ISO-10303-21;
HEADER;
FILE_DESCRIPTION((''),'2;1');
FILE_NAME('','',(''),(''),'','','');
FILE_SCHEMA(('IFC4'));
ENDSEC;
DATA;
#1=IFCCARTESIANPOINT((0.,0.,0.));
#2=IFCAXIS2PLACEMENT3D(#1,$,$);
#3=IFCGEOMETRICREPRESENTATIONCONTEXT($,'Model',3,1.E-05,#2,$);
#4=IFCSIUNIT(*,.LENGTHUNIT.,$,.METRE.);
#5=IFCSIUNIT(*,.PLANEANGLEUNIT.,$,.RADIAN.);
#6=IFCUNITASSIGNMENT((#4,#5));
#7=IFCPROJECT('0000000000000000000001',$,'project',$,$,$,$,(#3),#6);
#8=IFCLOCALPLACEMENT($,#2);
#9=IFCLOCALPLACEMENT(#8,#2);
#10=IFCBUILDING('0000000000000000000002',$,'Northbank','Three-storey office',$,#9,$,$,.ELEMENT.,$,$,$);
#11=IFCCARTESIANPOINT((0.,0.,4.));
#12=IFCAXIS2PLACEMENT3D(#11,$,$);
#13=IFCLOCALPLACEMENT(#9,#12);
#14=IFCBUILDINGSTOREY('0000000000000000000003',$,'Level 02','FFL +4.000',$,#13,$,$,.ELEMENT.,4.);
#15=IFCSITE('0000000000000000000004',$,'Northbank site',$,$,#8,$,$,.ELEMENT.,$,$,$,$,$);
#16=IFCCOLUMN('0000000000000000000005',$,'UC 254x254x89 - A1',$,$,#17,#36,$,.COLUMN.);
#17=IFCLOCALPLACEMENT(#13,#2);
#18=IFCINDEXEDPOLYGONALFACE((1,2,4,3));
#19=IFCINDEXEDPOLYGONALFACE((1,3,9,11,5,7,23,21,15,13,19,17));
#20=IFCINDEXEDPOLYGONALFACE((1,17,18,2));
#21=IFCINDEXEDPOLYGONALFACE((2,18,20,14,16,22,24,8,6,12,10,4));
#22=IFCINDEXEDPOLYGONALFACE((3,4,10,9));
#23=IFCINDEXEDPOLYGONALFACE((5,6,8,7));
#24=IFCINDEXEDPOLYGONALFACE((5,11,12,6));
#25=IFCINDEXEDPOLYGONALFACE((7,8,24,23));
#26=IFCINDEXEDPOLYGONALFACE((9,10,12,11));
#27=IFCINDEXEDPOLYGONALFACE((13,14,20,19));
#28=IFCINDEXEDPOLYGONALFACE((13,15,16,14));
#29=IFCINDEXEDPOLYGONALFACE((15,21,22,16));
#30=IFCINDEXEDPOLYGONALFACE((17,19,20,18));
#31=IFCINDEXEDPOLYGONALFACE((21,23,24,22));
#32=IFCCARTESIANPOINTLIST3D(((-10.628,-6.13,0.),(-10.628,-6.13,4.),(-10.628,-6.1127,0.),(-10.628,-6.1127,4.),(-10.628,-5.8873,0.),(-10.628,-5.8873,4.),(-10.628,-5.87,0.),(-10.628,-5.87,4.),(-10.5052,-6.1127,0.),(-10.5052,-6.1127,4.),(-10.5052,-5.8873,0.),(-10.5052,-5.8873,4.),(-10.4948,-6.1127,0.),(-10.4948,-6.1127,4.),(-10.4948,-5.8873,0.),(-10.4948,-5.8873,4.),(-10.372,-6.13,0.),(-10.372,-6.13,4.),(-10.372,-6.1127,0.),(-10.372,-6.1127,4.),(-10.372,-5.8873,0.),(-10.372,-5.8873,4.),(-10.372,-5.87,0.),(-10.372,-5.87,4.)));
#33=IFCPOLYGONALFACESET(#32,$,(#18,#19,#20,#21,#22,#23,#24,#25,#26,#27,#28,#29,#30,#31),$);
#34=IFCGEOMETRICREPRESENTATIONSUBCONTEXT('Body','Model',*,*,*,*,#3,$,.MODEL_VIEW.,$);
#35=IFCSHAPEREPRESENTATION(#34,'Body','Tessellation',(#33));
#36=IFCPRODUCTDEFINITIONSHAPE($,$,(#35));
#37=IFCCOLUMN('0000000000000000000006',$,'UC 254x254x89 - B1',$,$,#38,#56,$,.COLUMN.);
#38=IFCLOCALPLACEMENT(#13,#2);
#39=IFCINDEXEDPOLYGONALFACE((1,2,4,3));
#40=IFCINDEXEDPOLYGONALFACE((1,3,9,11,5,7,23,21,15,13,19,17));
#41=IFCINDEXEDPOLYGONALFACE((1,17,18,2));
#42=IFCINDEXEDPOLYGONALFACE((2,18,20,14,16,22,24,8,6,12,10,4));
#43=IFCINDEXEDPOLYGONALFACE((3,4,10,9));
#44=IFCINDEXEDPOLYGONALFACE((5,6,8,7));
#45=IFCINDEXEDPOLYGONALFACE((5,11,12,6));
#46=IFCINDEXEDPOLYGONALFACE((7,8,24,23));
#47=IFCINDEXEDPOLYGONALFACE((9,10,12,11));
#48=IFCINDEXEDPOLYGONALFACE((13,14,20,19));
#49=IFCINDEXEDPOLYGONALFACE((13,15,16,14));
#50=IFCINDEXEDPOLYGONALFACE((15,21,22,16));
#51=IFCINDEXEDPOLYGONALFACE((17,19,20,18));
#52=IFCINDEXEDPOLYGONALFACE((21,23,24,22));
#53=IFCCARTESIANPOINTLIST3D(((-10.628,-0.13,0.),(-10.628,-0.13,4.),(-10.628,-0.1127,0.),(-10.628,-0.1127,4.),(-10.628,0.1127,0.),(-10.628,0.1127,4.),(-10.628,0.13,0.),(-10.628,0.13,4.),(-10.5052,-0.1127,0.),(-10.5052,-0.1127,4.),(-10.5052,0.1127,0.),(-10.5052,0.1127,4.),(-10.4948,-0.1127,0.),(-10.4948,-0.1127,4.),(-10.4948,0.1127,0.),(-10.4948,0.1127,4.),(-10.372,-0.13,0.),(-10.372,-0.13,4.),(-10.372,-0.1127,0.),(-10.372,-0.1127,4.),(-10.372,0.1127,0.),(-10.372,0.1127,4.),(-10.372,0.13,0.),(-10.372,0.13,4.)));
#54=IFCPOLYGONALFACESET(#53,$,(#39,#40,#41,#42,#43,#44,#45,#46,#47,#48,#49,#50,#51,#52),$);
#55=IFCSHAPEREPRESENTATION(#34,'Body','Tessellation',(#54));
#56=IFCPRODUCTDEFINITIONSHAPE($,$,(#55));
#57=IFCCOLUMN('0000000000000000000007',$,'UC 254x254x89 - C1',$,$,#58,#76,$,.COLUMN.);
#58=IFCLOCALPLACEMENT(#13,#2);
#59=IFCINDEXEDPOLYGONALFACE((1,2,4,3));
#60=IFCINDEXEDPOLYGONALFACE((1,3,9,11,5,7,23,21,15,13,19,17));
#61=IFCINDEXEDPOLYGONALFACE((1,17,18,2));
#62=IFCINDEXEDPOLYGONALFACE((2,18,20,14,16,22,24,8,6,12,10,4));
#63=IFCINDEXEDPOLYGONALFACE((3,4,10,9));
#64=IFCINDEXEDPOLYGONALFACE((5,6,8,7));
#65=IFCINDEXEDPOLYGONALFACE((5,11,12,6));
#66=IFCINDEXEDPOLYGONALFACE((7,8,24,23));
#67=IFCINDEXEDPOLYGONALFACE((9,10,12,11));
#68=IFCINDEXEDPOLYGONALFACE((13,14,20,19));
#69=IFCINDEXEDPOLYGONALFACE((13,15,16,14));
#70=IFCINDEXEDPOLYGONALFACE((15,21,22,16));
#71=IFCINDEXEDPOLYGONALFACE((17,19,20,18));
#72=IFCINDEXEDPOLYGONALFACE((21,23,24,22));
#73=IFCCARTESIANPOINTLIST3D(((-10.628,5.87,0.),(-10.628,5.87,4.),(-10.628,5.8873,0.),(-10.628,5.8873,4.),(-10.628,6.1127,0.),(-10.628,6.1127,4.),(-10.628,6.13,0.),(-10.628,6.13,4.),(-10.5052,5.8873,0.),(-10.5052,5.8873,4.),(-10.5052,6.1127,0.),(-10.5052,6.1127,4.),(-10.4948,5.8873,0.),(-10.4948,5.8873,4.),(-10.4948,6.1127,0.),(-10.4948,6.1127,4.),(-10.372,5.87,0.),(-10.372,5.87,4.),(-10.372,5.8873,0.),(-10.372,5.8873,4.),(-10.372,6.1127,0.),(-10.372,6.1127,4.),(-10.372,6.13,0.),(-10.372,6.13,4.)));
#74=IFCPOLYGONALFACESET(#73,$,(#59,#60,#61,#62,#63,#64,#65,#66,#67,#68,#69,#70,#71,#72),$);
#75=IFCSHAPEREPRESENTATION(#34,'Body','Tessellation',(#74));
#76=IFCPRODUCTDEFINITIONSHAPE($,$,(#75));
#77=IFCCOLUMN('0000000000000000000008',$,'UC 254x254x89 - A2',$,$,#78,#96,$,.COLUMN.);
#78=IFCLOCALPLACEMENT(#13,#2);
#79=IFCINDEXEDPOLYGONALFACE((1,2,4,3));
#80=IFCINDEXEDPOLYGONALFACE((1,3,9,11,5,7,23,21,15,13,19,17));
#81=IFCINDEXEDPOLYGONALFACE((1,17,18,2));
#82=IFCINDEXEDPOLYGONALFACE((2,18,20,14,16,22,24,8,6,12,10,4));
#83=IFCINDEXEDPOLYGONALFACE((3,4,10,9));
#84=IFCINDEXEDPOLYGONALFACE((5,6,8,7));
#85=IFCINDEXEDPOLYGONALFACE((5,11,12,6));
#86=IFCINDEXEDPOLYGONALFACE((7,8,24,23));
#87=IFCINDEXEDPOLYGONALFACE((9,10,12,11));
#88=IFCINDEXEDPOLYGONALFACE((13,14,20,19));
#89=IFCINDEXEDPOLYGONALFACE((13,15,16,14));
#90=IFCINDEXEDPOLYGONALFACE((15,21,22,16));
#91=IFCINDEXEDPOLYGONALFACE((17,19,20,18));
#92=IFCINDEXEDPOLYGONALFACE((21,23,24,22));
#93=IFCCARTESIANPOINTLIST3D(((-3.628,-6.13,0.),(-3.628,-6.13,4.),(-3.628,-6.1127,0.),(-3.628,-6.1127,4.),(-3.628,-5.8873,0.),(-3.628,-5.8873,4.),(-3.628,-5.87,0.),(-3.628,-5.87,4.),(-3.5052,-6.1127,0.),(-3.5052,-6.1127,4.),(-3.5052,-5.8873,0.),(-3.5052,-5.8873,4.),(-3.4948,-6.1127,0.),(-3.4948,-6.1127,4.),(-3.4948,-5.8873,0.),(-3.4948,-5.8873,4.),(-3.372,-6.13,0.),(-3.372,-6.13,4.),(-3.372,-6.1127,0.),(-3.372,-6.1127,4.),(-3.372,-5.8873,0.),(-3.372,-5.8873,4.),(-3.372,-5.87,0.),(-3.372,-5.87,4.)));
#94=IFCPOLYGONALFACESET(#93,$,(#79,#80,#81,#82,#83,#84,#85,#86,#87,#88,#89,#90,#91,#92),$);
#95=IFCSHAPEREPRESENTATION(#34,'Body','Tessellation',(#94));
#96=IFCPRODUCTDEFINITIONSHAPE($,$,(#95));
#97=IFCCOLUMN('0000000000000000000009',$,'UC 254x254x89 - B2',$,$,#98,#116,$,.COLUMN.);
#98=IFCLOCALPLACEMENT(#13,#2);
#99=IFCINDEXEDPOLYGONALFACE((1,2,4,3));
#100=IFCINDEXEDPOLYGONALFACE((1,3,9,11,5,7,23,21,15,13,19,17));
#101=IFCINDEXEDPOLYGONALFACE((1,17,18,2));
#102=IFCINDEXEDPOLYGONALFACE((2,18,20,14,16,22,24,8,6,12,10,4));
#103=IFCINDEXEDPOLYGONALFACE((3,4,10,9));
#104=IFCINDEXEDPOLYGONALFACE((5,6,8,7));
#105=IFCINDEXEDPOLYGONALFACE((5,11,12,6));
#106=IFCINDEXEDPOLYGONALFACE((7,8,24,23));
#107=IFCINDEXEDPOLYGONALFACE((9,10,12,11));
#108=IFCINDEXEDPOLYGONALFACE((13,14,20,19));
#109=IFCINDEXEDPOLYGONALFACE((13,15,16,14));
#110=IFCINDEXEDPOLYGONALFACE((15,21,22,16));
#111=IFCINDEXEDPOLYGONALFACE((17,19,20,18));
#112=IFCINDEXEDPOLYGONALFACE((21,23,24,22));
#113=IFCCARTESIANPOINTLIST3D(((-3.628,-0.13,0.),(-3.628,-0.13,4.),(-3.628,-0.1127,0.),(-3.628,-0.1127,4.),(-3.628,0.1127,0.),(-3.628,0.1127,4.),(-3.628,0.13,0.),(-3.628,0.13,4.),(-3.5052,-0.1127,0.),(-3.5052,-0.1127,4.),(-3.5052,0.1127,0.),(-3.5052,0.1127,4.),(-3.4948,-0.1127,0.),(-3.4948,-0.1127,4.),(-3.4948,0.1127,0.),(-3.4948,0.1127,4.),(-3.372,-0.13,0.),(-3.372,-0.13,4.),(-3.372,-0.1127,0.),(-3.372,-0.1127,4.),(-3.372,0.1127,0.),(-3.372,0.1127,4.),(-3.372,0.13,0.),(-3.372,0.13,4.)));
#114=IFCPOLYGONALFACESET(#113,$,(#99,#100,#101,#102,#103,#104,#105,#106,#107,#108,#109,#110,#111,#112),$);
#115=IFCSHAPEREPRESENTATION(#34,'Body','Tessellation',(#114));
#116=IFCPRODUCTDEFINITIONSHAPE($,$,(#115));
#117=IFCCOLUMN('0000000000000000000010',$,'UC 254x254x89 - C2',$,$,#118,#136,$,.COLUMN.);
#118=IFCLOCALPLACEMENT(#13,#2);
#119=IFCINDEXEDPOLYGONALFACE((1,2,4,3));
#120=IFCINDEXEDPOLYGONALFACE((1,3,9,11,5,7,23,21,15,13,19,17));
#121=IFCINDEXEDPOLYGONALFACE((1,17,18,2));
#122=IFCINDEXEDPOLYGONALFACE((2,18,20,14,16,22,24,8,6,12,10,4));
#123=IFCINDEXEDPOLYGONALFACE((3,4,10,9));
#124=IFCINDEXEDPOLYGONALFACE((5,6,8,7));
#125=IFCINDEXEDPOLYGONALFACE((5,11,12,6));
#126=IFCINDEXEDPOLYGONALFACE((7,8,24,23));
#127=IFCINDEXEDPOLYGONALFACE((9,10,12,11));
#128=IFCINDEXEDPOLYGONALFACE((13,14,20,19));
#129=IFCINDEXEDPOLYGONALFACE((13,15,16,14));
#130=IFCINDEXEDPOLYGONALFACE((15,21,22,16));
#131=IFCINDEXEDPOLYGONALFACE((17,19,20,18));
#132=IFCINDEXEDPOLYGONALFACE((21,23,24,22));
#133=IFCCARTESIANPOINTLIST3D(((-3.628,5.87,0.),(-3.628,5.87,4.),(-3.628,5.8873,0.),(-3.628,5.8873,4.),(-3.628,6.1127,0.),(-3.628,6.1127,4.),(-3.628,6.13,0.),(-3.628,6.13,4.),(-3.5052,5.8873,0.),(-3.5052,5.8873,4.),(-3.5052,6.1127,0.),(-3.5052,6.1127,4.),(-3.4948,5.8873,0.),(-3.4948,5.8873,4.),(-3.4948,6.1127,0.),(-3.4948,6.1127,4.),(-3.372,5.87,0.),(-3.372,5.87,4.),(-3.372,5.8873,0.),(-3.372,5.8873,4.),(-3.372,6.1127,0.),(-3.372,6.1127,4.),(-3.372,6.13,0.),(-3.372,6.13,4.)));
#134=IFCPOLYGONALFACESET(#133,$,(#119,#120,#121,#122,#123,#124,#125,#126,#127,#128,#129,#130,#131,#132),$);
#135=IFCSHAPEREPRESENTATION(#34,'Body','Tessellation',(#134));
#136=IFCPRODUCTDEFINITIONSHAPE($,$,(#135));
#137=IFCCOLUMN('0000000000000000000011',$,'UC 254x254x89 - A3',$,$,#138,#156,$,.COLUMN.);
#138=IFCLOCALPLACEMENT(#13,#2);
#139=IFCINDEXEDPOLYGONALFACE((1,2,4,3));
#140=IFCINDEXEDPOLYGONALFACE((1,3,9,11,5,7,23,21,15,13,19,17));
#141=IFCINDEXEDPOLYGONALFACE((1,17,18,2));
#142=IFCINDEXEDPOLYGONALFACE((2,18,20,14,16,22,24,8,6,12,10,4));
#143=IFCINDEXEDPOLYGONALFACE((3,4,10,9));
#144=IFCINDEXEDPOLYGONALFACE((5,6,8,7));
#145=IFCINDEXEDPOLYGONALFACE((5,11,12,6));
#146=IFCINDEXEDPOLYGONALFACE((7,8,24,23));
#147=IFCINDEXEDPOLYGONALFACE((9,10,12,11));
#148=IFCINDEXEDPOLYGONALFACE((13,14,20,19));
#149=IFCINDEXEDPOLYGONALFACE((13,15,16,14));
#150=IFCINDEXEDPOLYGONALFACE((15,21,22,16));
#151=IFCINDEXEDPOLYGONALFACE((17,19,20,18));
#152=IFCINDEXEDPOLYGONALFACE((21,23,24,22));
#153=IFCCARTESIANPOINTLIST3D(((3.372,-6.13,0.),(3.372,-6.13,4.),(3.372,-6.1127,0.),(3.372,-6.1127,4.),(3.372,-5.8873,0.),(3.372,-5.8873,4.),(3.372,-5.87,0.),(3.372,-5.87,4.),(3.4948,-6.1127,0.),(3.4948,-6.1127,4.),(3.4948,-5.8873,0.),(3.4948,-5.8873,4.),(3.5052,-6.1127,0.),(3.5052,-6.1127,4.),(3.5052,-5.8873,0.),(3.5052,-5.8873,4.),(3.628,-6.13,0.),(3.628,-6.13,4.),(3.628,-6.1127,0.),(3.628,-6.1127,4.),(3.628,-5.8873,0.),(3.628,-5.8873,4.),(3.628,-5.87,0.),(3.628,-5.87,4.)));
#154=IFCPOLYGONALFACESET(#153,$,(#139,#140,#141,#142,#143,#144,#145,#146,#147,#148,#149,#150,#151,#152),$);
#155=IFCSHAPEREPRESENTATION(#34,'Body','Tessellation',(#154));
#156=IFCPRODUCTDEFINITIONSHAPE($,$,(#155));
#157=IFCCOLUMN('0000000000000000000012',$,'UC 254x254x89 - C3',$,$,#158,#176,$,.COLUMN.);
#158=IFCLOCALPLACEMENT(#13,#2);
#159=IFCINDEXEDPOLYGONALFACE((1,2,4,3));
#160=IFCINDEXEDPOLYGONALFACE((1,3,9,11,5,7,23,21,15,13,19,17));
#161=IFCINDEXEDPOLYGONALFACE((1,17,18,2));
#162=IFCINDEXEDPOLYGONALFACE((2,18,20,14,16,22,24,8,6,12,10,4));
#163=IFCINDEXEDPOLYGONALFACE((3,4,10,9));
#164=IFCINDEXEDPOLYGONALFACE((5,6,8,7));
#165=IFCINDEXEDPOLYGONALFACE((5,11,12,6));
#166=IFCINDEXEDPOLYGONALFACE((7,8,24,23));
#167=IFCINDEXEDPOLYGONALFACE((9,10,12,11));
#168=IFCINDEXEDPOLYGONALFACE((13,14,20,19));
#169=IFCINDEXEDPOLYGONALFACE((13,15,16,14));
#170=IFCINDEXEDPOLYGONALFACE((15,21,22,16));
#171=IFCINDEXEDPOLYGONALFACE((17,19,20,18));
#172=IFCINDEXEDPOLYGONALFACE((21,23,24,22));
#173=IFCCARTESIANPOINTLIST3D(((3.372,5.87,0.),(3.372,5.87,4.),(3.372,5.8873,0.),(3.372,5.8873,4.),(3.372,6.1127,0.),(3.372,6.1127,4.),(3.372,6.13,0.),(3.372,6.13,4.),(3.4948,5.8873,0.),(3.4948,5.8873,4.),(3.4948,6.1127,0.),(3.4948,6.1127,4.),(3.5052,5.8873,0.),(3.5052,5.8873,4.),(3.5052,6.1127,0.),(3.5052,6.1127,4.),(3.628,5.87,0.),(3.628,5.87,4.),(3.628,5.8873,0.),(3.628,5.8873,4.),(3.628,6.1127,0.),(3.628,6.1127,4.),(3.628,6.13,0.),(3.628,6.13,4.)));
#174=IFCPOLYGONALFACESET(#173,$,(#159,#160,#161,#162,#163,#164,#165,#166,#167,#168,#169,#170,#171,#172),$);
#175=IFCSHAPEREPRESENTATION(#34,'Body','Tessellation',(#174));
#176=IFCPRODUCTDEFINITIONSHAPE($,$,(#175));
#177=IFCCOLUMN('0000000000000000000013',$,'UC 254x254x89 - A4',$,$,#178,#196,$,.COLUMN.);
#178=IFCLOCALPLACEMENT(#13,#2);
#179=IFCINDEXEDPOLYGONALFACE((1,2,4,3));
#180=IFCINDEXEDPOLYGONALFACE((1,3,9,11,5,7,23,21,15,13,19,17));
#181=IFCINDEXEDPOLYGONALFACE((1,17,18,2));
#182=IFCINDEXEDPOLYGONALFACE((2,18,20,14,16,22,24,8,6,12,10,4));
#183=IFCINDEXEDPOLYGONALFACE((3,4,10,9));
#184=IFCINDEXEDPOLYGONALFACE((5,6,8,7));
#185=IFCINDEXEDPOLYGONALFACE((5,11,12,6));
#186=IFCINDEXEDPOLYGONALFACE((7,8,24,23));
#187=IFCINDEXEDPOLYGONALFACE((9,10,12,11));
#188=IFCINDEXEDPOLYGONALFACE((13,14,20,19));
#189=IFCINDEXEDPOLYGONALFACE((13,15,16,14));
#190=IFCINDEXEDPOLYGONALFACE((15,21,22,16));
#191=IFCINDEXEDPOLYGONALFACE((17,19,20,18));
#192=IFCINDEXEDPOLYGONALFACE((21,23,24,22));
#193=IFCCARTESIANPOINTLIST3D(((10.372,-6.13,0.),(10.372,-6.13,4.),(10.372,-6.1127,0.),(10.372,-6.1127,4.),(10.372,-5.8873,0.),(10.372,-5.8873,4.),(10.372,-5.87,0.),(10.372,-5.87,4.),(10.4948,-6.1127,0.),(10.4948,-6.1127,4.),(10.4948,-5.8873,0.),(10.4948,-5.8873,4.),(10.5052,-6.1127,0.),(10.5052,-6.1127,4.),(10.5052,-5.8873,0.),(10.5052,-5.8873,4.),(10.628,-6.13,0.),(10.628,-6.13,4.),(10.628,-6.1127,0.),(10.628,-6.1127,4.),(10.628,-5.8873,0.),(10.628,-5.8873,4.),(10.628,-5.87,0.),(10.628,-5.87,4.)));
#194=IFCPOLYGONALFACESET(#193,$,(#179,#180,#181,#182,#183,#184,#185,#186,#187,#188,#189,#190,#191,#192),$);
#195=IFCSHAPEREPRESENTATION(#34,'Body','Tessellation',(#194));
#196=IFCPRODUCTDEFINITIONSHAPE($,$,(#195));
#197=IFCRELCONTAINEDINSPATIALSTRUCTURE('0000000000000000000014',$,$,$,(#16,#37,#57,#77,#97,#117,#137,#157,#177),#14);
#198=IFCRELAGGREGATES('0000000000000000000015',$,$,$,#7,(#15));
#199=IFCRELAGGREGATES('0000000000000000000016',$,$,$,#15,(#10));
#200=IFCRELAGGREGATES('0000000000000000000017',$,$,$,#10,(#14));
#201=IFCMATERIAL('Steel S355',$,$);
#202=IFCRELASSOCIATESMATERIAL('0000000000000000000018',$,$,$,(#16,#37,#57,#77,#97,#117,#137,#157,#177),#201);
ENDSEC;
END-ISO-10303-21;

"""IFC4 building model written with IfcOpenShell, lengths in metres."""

from ifc_helpers import new_model, si_unit, frame, origin, place, context, subcontext, project, spatial, i_section, extrude, material, element, save


model = new_model("IFC4")

# Units and contexts
model_context = context("Model", 3, precision=1e-05, world=origin())
body_context = subcontext(model_context, "Body", "Model", "MODEL_VIEW")
ifc_project = project(units=[si_unit("LENGTHUNIT", "METRE"), si_unit("PLANEANGLEUNIT", "RADIAN")], contexts=[model_context])

# Site, building, storey
site_placement = place(None, origin())
site = spatial("IfcSite", under=ifc_project, at=site_placement, Name="Northbank site", CompositionType="ELEMENT")
building_placement = place(site_placement, origin())
building = spatial("IfcBuilding", under=site, at=building_placement, Name="Northbank", Description="Three-storey office", CompositionType="ELEMENT")
storey_placement = place(building_placement, frame((0.0, 0.0, 4.0)))
storey = spatial("IfcBuildingStorey", under=building, at=storey_placement, Name="Level 02", Description="FFL +4.000", CompositionType="ELEMENT", Elevation=4.0)

# Columns
ifc_material = material(Name="Steel S355")
column_1_placement = place(storey_placement, frame((0.0, 0.0, -4.0)))
element("IfcColumn", 1, at=column_1_placement, inside=storey, material=ifc_material, Name="UC 254x254x89 - A1", PredefinedType="COLUMN", context=body_context, shape_type="SweptSolid", body=[
    extrude(i_section(OverallWidth=0.256, OverallDepth=0.26, WebThickness=0.0103, FlangeThickness=0.0173), frame((-10.5, -6.0, 4.0), z_axis=(0.0, 0.0, 1.0), x_axis=(1.0, 0.0, 0.0)), (0.0, 0.0, 1.0), 4.0),
])
column_2_placement = place(storey_placement, frame((0.0, 0.0, -4.0)))
element("IfcColumn", 2, at=column_2_placement, inside=storey, material=ifc_material, Name="UC 254x254x89 - B1", PredefinedType="COLUMN", context=body_context, shape_type="SweptSolid", body=[
    extrude(i_section(OverallWidth=0.256, OverallDepth=0.26, WebThickness=0.0103, FlangeThickness=0.0173), frame((-10.5, 0.0, 4.0), z_axis=(0.0, 0.0, 1.0), x_axis=(1.0, 0.0, 0.0)), (0.0, 0.0, 1.0), 4.0),
])
column_3_placement = place(storey_placement, frame((0.0, 0.0, -4.0)))
element("IfcColumn", 3, at=column_3_placement, inside=storey, material=ifc_material, Name="UC 254x254x89 - C1", PredefinedType="COLUMN", context=body_context, shape_type="SweptSolid", body=[
    extrude(i_section(OverallWidth=0.256, OverallDepth=0.26, WebThickness=0.0103, FlangeThickness=0.0173), frame((-10.5, 6.0, 4.0), z_axis=(0.0, 0.0, 1.0), x_axis=(1.0, 0.0, 0.0)), (0.0, 0.0, 1.0), 4.0),
])
column_4_placement = place(storey_placement, frame((0.0, 0.0, -4.0)))
element("IfcColumn", 4, at=column_4_placement, inside=storey, material=ifc_material, Name="UC 254x254x89 - A2", PredefinedType="COLUMN", context=body_context, shape_type="SweptSolid", body=[
    extrude(i_section(OverallWidth=0.256, OverallDepth=0.26, WebThickness=0.0103, FlangeThickness=0.0173), frame((-3.5, -6.0, 4.0), z_axis=(0.0, 0.0, 1.0), x_axis=(1.0, 0.0, 0.0)), (0.0, 0.0, 1.0), 4.0),
])
column_5_placement = place(storey_placement, frame((0.0, 0.0, -4.0)))
element("IfcColumn", 5, at=column_5_placement, inside=storey, material=ifc_material, Name="UC 254x254x89 - B2", PredefinedType="COLUMN", context=body_context, shape_type="SweptSolid", body=[
    extrude(i_section(OverallWidth=0.256, OverallDepth=0.26, WebThickness=0.0103, FlangeThickness=0.0173), frame((-3.5, 0.0, 4.0), z_axis=(0.0, 0.0, 1.0), x_axis=(1.0, 0.0, 0.0)), (0.0, 0.0, 1.0), 4.0),
])
column_6_placement = place(storey_placement, frame((0.0, 0.0, -4.0)))
element("IfcColumn", 6, at=column_6_placement, inside=storey, material=ifc_material, Name="UC 254x254x89 - C2", PredefinedType="COLUMN", context=body_context, shape_type="SweptSolid", body=[
    extrude(i_section(OverallWidth=0.256, OverallDepth=0.26, WebThickness=0.0103, FlangeThickness=0.0173), frame((-3.5, 6.0, 4.0), z_axis=(0.0, 0.0, 1.0), x_axis=(1.0, 0.0, 0.0)), (0.0, 0.0, 1.0), 4.0),
])
column_7_placement = place(storey_placement, frame((0.0, 0.0, -4.0)))
element("IfcColumn", 7, at=column_7_placement, inside=storey, material=ifc_material, Name="UC 254x254x89 - A3", PredefinedType="COLUMN", context=body_context, shape_type="SweptSolid", body=[
    extrude(i_section(OverallWidth=0.256, OverallDepth=0.26, WebThickness=0.0103, FlangeThickness=0.0173), frame((3.5, -6.0, 4.0), z_axis=(0.0, 0.0, 1.0), x_axis=(1.0, 0.0, 0.0)), (0.0, 0.0, 1.0), 4.0),
])
column_8_placement = place(storey_placement, frame((0.0, 0.0, -4.0)))
element("IfcColumn", 8, at=column_8_placement, inside=storey, material=ifc_material, Name="UC 254x254x89 - C3", PredefinedType="COLUMN", context=body_context, shape_type="SweptSolid", body=[
    extrude(i_section(OverallWidth=0.256, OverallDepth=0.26, WebThickness=0.0103, FlangeThickness=0.0173), frame((3.5, 6.0, 4.0), z_axis=(0.0, 0.0, 1.0), x_axis=(1.0, 0.0, 0.0)), (0.0, 0.0, 1.0), 4.0),
])
column_9_placement = place(storey_placement, frame((0.0, 0.0, -4.0)))
element("IfcColumn", 9, at=column_9_placement, inside=storey, material=ifc_material, Name="UC 254x254x89 - A4", PredefinedType="COLUMN", context=body_context, shape_type="SweptSolid", body=[
    extrude(i_section(OverallWidth=0.256, OverallDepth=0.26, WebThickness=0.0103, FlangeThickness=0.0173), frame((10.5, -6.0, 4.0), z_axis=(0.0, 0.0, 1.0), x_axis=(1.0, 0.0, 0.0)), (0.0, 0.0, 1.0), 4.0),
])

save(model, "model.ifc")
